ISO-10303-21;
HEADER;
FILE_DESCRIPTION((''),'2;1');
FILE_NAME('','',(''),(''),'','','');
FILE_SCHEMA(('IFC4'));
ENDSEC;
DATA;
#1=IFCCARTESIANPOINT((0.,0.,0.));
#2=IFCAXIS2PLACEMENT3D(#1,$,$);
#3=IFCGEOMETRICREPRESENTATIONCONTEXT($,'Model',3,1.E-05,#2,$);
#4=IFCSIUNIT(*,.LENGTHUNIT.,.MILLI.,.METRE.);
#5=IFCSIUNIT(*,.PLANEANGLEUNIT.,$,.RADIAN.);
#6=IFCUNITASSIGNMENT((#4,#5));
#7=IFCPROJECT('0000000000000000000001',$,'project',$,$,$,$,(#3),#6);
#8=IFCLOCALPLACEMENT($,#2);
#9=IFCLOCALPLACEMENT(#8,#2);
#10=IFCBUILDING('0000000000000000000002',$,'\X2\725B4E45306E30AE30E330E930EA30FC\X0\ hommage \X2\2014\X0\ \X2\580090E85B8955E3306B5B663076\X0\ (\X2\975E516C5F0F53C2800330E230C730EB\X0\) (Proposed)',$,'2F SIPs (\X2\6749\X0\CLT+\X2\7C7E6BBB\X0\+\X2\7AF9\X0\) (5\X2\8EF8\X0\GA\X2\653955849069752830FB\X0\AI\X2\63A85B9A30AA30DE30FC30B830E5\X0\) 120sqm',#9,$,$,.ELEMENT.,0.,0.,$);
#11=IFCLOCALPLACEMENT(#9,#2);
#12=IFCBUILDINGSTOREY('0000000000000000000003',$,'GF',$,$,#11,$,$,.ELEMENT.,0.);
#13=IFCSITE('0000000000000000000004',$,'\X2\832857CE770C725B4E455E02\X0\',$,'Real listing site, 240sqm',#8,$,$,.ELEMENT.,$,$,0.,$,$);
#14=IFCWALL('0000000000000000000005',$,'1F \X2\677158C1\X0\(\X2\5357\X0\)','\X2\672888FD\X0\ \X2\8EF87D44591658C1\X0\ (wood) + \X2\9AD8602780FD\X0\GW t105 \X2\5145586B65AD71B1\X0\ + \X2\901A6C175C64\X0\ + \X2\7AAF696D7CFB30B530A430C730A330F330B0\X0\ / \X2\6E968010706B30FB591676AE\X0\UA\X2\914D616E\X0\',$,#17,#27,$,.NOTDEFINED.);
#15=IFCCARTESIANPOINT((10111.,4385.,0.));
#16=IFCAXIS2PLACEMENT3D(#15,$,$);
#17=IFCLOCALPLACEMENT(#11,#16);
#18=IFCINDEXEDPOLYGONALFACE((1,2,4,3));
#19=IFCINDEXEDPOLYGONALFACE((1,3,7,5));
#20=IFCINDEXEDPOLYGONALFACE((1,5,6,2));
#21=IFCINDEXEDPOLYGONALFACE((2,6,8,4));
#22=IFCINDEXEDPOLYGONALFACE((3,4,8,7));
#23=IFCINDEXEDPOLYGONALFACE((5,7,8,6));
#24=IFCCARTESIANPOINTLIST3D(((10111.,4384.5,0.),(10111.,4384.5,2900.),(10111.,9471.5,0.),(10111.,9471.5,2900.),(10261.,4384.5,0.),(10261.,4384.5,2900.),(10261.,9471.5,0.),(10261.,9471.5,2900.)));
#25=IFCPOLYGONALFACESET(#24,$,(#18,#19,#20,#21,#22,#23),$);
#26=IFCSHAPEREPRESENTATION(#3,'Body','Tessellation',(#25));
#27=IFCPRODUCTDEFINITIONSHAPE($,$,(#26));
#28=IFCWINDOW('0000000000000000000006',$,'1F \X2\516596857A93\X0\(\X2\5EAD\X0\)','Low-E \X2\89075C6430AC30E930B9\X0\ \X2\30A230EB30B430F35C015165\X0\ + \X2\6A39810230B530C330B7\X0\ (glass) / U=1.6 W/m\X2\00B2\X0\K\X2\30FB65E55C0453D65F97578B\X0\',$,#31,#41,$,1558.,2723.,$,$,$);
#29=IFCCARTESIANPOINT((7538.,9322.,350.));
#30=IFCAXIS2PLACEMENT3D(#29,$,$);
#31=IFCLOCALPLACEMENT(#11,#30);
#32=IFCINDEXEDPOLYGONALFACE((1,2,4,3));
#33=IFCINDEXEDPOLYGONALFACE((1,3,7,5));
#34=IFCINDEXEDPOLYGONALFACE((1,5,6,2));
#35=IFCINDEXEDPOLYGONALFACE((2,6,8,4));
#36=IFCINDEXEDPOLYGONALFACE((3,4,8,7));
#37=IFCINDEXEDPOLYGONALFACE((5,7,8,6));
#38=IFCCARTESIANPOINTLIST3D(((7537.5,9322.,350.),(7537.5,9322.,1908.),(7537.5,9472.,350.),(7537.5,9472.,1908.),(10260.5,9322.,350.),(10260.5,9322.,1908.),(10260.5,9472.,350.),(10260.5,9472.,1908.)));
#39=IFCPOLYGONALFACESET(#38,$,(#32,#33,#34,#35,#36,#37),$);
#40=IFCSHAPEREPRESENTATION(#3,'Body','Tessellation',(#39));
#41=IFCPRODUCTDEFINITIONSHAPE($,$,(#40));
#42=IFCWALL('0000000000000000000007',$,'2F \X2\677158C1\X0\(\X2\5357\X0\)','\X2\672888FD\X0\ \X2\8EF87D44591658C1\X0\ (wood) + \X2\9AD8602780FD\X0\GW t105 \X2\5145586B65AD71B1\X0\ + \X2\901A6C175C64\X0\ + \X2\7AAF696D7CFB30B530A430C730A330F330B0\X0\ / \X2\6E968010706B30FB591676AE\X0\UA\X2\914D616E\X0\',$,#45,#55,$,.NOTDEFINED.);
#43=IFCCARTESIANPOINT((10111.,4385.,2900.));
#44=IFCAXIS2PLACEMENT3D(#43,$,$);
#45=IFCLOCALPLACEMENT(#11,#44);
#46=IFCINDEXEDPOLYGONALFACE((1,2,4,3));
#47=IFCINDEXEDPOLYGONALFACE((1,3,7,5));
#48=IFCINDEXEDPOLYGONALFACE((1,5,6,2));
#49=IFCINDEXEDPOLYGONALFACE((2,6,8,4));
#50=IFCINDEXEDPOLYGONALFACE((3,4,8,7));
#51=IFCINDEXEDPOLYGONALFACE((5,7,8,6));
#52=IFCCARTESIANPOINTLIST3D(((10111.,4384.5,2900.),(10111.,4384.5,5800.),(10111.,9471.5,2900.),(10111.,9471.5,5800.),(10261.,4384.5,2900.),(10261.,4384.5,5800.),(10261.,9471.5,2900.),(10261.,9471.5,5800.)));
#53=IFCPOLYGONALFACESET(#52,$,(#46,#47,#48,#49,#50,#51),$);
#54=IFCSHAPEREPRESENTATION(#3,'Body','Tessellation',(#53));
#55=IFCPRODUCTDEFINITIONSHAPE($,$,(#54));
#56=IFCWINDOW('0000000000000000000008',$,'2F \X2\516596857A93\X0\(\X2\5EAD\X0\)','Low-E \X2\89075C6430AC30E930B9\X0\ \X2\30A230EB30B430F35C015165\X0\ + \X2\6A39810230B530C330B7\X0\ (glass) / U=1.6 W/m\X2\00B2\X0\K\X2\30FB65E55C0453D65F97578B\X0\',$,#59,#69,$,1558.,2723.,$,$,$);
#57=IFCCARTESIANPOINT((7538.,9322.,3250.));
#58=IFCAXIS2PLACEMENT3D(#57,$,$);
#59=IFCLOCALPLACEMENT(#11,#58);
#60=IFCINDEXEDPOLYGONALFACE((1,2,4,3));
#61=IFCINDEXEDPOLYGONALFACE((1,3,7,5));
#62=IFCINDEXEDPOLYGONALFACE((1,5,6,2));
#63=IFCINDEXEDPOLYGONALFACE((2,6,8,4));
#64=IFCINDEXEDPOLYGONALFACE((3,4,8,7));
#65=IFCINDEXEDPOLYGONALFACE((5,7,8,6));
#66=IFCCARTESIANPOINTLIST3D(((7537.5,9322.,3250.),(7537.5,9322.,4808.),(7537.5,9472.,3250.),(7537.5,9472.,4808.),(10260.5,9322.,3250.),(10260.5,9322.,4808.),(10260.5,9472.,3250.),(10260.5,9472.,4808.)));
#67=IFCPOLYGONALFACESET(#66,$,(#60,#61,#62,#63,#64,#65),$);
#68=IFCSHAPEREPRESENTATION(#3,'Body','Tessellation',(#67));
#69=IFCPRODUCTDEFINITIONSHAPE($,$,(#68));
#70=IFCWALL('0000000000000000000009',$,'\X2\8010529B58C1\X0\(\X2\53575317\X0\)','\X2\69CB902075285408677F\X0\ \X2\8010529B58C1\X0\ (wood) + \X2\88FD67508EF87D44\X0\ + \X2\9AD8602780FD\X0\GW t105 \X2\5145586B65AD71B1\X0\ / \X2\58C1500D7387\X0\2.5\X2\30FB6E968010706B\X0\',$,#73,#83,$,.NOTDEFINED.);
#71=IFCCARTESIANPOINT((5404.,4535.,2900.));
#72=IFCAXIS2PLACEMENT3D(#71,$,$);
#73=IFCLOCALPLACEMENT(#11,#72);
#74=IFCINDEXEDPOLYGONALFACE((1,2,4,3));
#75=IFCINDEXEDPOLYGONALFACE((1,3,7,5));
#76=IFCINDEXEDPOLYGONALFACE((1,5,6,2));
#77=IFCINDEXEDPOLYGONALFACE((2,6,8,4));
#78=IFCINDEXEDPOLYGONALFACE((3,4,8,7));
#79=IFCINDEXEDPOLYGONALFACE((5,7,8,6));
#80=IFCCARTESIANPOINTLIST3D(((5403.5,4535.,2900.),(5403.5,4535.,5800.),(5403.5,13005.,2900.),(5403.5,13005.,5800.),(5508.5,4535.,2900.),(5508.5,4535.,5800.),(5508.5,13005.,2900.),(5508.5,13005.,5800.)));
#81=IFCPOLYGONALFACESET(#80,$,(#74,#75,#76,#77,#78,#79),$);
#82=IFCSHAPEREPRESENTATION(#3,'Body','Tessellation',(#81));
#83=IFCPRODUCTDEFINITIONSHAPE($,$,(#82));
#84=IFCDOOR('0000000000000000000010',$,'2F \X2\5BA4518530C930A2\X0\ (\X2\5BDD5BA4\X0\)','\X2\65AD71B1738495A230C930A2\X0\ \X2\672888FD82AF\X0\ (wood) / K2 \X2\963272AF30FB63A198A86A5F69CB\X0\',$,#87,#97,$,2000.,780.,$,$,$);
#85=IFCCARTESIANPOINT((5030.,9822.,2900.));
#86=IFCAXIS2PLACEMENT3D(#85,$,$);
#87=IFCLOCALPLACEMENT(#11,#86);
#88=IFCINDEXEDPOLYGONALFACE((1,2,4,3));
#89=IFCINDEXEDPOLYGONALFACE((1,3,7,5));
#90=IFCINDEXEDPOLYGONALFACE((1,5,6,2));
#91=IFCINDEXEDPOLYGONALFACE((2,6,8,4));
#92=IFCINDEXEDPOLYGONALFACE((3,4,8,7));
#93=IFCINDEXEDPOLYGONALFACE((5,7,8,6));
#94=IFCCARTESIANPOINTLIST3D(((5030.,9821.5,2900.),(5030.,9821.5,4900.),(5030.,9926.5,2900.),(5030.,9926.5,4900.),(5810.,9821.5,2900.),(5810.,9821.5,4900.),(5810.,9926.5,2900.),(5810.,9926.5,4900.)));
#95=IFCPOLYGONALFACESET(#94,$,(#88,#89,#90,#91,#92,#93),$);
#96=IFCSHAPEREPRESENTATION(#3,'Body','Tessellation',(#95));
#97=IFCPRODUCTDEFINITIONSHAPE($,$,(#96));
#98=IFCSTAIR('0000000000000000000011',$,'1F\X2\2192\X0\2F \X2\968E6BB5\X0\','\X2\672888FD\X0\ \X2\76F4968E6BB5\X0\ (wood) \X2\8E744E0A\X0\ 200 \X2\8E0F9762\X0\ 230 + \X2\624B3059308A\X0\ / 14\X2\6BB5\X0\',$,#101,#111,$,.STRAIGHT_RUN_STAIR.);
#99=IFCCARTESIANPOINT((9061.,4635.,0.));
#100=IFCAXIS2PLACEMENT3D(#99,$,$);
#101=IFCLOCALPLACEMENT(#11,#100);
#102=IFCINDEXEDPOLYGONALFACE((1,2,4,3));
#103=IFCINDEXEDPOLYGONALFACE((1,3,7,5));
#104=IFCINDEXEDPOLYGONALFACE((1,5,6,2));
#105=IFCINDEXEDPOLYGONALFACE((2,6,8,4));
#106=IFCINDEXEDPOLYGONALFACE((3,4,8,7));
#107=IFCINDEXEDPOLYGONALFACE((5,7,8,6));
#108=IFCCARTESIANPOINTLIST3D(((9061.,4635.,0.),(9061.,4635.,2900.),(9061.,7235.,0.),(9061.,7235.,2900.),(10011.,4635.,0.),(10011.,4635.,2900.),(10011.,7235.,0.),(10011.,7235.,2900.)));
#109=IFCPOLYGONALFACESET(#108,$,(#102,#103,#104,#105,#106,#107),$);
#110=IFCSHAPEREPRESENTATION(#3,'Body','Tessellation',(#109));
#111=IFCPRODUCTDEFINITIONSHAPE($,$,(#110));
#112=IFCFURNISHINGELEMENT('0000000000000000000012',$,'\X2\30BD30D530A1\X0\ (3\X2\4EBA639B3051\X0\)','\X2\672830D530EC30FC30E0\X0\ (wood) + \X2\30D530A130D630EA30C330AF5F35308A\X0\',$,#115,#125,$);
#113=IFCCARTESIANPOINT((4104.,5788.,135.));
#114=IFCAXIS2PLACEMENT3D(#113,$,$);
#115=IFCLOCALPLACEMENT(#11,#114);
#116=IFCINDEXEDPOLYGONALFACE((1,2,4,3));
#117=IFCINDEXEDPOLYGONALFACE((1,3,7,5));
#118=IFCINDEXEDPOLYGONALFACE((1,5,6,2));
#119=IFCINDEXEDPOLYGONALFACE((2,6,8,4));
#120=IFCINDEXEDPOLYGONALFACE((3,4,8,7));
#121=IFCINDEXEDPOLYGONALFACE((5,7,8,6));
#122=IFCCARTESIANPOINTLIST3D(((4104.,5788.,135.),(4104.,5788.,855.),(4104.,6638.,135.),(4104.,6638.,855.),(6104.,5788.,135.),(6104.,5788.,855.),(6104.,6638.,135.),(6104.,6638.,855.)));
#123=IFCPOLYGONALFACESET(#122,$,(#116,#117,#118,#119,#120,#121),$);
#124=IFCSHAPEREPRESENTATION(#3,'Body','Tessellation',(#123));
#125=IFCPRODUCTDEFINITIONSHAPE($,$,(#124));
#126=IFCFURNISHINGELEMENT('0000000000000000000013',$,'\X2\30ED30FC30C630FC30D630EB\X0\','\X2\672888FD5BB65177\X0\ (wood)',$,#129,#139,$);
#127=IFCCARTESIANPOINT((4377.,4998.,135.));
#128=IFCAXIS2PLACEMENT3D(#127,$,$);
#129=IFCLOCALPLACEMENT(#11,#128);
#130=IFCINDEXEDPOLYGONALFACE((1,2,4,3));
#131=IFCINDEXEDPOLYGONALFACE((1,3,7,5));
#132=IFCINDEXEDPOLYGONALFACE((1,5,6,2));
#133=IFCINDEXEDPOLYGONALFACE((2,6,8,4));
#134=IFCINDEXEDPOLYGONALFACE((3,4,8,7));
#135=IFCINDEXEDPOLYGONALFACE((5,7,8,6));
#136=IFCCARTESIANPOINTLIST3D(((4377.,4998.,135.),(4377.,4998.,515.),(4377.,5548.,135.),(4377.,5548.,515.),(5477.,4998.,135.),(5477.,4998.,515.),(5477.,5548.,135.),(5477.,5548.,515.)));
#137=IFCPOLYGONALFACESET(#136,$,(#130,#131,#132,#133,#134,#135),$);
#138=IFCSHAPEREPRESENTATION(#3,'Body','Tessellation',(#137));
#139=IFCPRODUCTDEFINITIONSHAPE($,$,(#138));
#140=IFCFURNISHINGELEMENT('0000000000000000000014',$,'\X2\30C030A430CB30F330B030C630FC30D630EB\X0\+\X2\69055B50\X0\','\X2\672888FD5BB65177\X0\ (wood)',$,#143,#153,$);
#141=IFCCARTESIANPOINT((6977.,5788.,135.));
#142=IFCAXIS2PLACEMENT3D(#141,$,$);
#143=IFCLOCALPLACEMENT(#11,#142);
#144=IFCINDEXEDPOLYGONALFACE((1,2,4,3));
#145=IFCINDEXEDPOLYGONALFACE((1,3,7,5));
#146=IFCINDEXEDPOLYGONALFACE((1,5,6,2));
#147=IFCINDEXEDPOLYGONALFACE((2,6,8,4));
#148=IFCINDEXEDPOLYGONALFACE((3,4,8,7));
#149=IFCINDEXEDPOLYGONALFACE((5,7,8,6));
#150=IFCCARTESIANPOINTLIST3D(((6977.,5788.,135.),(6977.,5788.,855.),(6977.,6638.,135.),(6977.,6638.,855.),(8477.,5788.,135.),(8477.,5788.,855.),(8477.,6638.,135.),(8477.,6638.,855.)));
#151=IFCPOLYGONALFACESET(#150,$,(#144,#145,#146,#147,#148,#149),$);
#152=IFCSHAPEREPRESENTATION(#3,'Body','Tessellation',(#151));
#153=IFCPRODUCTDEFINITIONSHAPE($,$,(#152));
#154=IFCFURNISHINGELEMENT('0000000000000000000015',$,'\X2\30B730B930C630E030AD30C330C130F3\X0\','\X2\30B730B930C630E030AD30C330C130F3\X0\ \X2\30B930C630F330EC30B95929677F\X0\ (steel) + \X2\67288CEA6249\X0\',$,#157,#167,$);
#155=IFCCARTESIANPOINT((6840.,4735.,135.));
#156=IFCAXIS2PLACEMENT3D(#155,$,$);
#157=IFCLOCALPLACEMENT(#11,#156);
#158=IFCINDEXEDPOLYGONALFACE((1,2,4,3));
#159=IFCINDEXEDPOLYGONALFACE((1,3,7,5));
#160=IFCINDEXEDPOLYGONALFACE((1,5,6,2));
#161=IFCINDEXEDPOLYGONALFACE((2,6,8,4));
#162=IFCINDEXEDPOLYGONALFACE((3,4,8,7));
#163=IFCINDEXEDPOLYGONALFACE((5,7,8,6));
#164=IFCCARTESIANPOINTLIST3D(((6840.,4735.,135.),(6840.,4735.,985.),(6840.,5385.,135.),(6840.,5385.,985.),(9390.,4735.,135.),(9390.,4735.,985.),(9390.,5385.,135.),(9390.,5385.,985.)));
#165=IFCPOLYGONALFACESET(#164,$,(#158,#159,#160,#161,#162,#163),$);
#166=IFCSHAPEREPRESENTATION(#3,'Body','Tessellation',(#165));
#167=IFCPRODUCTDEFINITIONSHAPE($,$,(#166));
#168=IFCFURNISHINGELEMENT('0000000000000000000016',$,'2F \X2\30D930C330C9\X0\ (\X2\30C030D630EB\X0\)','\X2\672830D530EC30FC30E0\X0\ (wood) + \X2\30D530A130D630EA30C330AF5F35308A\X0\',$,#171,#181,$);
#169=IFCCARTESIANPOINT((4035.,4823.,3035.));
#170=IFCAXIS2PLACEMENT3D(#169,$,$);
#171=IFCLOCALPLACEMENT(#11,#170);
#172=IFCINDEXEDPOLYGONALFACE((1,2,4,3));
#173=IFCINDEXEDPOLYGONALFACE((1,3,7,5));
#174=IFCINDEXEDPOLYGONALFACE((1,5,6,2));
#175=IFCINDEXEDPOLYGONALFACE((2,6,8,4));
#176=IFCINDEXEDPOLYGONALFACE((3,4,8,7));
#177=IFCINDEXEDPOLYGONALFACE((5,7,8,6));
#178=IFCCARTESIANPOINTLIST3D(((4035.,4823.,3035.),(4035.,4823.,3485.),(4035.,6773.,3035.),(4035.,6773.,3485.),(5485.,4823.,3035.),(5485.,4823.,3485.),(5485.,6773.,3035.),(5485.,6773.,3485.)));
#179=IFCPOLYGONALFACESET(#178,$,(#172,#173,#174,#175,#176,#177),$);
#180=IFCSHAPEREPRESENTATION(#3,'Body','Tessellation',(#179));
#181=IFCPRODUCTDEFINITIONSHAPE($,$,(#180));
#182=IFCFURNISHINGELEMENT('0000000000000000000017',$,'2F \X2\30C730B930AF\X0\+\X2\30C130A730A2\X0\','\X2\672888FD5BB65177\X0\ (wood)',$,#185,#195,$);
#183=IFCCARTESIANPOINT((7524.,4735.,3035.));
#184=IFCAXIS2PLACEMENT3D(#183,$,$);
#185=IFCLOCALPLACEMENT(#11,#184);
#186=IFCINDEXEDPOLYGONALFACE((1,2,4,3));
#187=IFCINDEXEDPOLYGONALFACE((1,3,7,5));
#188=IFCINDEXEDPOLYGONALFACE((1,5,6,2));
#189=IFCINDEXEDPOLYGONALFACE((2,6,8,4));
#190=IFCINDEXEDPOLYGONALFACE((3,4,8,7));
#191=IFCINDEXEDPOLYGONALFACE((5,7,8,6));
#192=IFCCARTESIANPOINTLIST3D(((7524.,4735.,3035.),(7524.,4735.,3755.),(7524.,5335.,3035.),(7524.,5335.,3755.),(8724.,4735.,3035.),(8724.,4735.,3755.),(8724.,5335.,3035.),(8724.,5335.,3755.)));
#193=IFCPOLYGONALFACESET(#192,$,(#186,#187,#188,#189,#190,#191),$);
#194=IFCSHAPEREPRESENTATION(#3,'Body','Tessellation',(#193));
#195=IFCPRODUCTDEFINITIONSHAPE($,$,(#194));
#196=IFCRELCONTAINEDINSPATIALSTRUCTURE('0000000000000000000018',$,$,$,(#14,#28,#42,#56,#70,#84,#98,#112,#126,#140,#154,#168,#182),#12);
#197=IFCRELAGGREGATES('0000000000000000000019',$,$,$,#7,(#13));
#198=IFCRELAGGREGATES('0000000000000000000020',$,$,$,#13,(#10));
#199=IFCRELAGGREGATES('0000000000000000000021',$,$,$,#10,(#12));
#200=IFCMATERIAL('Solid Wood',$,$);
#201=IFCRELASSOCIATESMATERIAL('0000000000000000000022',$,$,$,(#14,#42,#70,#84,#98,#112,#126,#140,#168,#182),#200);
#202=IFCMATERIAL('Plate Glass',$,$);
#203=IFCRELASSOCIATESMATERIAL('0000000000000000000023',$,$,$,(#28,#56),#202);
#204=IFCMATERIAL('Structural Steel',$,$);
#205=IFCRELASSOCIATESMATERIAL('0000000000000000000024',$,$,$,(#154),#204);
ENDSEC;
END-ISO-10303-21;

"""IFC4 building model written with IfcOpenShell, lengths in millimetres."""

from ifc_helpers import new_model, si_unit, frame, frame_2d, origin, place, context, project, spatial, rectangle, extrude, material, element, fill, save


model = new_model("IFC4")

# Units and contexts
model_context = context("Model", 3, precision=1e-05, world=origin())
ifc_project = project(units=[si_unit("LENGTHUNIT", "METRE", prefix="MILLI"), si_unit("PLANEANGLEUNIT", "RADIAN")], contexts=[model_context])

# Site, building, storey
site_placement = place(None, origin())
site = spatial("IfcSite", under=ifc_project, at=site_placement, Name="茨城県牛久市", ObjectType="Real listing site, 240sqm", CompositionType="ELEMENT", RefElevation=0.0)
building_placement = place(site_placement, origin())
building = spatial("IfcBuilding", under=site, at=building_placement, Name="牛久のギャラリー hommage — 堀部安嗣に学ぶ (非公式参考モデル) (Proposed)", ObjectType="2F SIPs (杉CLT+籾殻+竹) (5軸GA改善適用・AI推定オマージュ) 120sqm", CompositionType="ELEMENT", ElevationOfRefHeight=0.0, ElevationOfTerrain=0.0)
storey_placement = place(building_placement, origin())
storey = spatial("IfcBuildingStorey", under=building, at=storey_placement, Name="GF", CompositionType="ELEMENT", Elevation=0.0)

# Wall, opening, window
ifc_material_1 = material(Name="Solid Wood")
wall_1_placement = place(storey_placement, frame((10111.0, 4385.0, 0.0)))
wall_1 = element("IfcWall", 1, at=wall_1_placement, inside=storey, material=ifc_material_1, Name="1F 東壁(南)", Description="木製 軸組外壁 (wood) + 高性能GW t105 充填断熱 + 通気層 + 窯業系サイディング / 準耐火・外皮UA配慮", PredefinedType="NOTDEFINED", context=model_context, shape_type="SweptSolid", body=[
    extrude(rectangle(XDim=150.0, YDim=5087.0, at=frame_2d((75.0, 2543.0))), frame((10111.0, 4385.0, 0.0)), (0.0, 0.0, 1.0), 2900.0),
])
opening_1_placement = place(storey_placement, frame((7538.0, 9322.0, 350.0)))
opening_1 = element("IfcOpeningElement", 2, at=opening_1_placement, cuts=wall_1, PredefinedType="NOTDEFINED", context=model_context, shape_type="SweptSolid", body=[
    extrude(rectangle(XDim=2723.0, YDim=150.0, at=frame_2d((1361.0, 75.0))), frame((7538.0, 9322.0, 350.0)), (0.0, 0.0, 1.0), 1558.0),
])
ifc_material_2 = material(Name="Plate Glass")
window_1_placement = place(storey_placement, frame((7538.0, 9322.0, 350.0)))
window_1 = element("IfcWindow", 3, at=window_1_placement, inside=storey, material=ifc_material_2, Name="1F 入隅窓(庭)", Description="Low-E 複層ガラス アルゴン封入 + 樹脂サッシ (glass) / U=1.6 W/m²K・日射取得型", OverallHeight=1558.0, OverallWidth=2723.0, context=model_context, shape_type="SweptSolid", body=[
    extrude(rectangle(XDim=2723.0, YDim=150.0, at=frame_2d((1361.0, 75.0))), frame((7538.0, 9322.0, 350.0)), (0.0, 0.0, 1.0), 1558.0),
])
fill(opening_1, window_1)

# Wall, opening, window
wall_2_placement = place(storey_placement, frame((10111.0, 4385.0, 2900.0)))
wall_2 = element("IfcWall", 4, at=wall_2_placement, inside=storey, material=ifc_material_1, Name="2F 東壁(南)", Description="木製 軸組外壁 (wood) + 高性能GW t105 充填断熱 + 通気層 + 窯業系サイディング / 準耐火・外皮UA配慮", PredefinedType="NOTDEFINED", context=model_context, shape_type="SweptSolid", body=[
    extrude(rectangle(XDim=150.0, YDim=5087.0, at=frame_2d((75.0, 2543.0))), frame((10111.0, 4385.0, 2900.0)), (0.0, 0.0, 1.0), 2900.0),
])
opening_2_placement = place(storey_placement, frame((7538.0, 9322.0, 3250.0)))
opening_2 = element("IfcOpeningElement", 5, at=opening_2_placement, cuts=wall_2, PredefinedType="NOTDEFINED", context=model_context, shape_type="SweptSolid", body=[
    extrude(rectangle(XDim=2723.0, YDim=150.0, at=frame_2d((1361.0, 75.0))), frame((7538.0, 9322.0, 3250.0)), (0.0, 0.0, 1.0), 1558.0),
])
window_2_placement = place(storey_placement, frame((7538.0, 9322.0, 3250.0)))
window_2 = element("IfcWindow", 6, at=window_2_placement, inside=storey, material=ifc_material_2, Name="2F 入隅窓(庭)", Description="Low-E 複層ガラス アルゴン封入 + 樹脂サッシ (glass) / U=1.6 W/m²K・日射取得型", OverallHeight=1558.0, OverallWidth=2723.0, context=model_context, shape_type="SweptSolid", body=[
    extrude(rectangle(XDim=2723.0, YDim=150.0, at=frame_2d((1361.0, 75.0))), frame((7538.0, 9322.0, 3250.0)), (0.0, 0.0, 1.0), 1558.0),
])
fill(opening_2, window_2)

# Wall, opening, door
wall_3_placement = place(storey_placement, frame((5404.0, 4535.0, 2900.0)))
wall_3 = element("IfcWall", 7, at=wall_3_placement, inside=storey, material=ifc_material_1, Name="耐力壁(南北)", Description="構造用合板 耐力壁 (wood) + 製材軸組 + 高性能GW t105 充填断熱 / 壁倍率2.5・準耐火", PredefinedType="NOTDEFINED", context=model_context, shape_type="SweptSolid", body=[
    extrude(rectangle(XDim=105.0, YDim=8470.0, at=frame_2d((52.0, 4235.0))), frame((5404.0, 4535.0, 2900.0)), (0.0, 0.0, 1.0), 2900.0),
])
opening_3_placement = place(storey_placement, frame((5030.0, 9822.0, 2900.0)))
opening_3 = element("IfcOpeningElement", 8, at=opening_3_placement, cuts=wall_3, PredefinedType="NOTDEFINED", context=model_context, shape_type="SweptSolid", body=[
    extrude(rectangle(XDim=780.0, YDim=105.0, at=frame_2d((390.0, 52.0))), frame((5030.0, 9822.0, 2900.0)), (0.0, 0.0, 1.0), 2000.0),
])
door_1_placement = place(storey_placement, frame((5030.0, 9822.0, 2900.0)))
door_1 = element("IfcDoor", 9, at=door_1_placement, inside=storey, material=ifc_material_1, Name="2F 室内ドア (寝室)", Description="断熱玄関ドア 木製芯 (wood) / K2 防犯・採風機構", OverallHeight=2000.0, OverallWidth=780.0, context=model_context, shape_type="SweptSolid", body=[
    extrude(rectangle(XDim=780.0, YDim=105.0, at=frame_2d((390.0, 52.0))), frame((5030.0, 9822.0, 2900.0)), (0.0, 0.0, 1.0), 2000.0),
])
fill(opening_3, door_1)

# Stair
stair_placement = place(storey_placement, frame((9061.0, 4635.0, 0.0)))
element("IfcStair", 10, at=stair_placement, inside=storey, material=ifc_material_1, Name="1F→2F 階段", Description="木製 直階段 (wood) 蹴上 200 踏面 230 + 手すり / 14段", PredefinedType="STRAIGHT_RUN_STAIR", context=model_context, shape_type="SweptSolid", body=[
    extrude(rectangle(XDim=950.0, YDim=2600.0, at=frame_2d((475.0, 1300.0))), frame((9061.0, 4635.0, 0.0)), (0.0, 0.0, 1.0), 2900.0),
])

# Furnishing elements
furnishing_1_placement = place(storey_placement, frame((4104.0, 5788.0, 135.0)))
element("IfcFurnishingElement", 11, at=furnishing_1_placement, inside=storey, material=ifc_material_1, Name="ソファ (3人掛け)", Description="木フレーム (wood) + ファブリック張り", context=model_context, shape_type="SweptSolid", body=[
    extrude(rectangle(XDim=2000.0, YDim=850.0, at=frame_2d((1000.0, 425.0))), frame((4104.0, 5788.0, 135.0)), (0.0, 0.0, 1.0), 720.0),
])
furnishing_2_placement = place(storey_placement, frame((4377.0, 4998.0, 135.0)))
element("IfcFurnishingElement", 12, at=furnishing_2_placement, inside=storey, material=ifc_material_1, Name="ローテーブル", Description="木製家具 (wood)", context=model_context, shape_type="SweptSolid", body=[
    extrude(rectangle(XDim=1100.0, YDim=550.0, at=frame_2d((550.0, 275.0))), frame((4377.0, 4998.0, 135.0)), (0.0, 0.0, 1.0), 380.0),
])
furnishing_3_placement = place(storey_placement, frame((6977.0, 5788.0, 135.0)))
element("IfcFurnishingElement", 13, at=furnishing_3_placement, inside=storey, material=ifc_material_1, Name="ダイニングテーブル+椅子", Description="木製家具 (wood)", context=model_context, shape_type="SweptSolid", body=[
    extrude(rectangle(XDim=1500.0, YDim=850.0, at=frame_2d((750.0, 425.0))), frame((6977.0, 5788.0, 135.0)), (0.0, 0.0, 1.0), 720.0),
])
ifc_material_3 = material(Name="Structural Steel")
furnishing_4_placement = place(storey_placement, frame((6840.0, 4735.0, 135.0)))
element("IfcFurnishingElement", 14, at=furnishing_4_placement, inside=storey, material=ifc_material_3, Name="システムキッチン", Description="システムキッチン ステンレス天板 (steel) + 木質扉", context=model_context, shape_type="SweptSolid", body=[
    extrude(rectangle(XDim=2550.0, YDim=650.0, at=frame_2d((1275.0, 325.0))), frame((6840.0, 4735.0, 135.0)), (0.0, 0.0, 1.0), 850.0),
])
furnishing_5_placement = place(storey_placement, frame((4035.0, 4823.0, 3035.0)))
element("IfcFurnishingElement", 15, at=furnishing_5_placement, inside=storey, material=ifc_material_1, Name="2F ベッド (ダブル)", Description="木フレーム (wood) + ファブリック張り", context=model_context, shape_type="SweptSolid", body=[
    extrude(rectangle(XDim=1450.0, YDim=1950.0, at=frame_2d((725.0, 975.0))), frame((4035.0, 4823.0, 3035.0)), (0.0, 0.0, 1.0), 450.0),
])
furnishing_6_placement = place(storey_placement, frame((7524.0, 4735.0, 3035.0)))
element("IfcFurnishingElement", 16, at=furnishing_6_placement, inside=storey, material=ifc_material_1, Name="2F デスク+チェア", Description="木製家具 (wood)", context=model_context, shape_type="SweptSolid", body=[
    extrude(rectangle(XDim=1200.0, YDim=600.0, at=frame_2d((600.0, 300.0))), frame((7524.0, 4735.0, 3035.0)), (0.0, 0.0, 1.0), 720.0),
])

save(model, "model.ifc")
